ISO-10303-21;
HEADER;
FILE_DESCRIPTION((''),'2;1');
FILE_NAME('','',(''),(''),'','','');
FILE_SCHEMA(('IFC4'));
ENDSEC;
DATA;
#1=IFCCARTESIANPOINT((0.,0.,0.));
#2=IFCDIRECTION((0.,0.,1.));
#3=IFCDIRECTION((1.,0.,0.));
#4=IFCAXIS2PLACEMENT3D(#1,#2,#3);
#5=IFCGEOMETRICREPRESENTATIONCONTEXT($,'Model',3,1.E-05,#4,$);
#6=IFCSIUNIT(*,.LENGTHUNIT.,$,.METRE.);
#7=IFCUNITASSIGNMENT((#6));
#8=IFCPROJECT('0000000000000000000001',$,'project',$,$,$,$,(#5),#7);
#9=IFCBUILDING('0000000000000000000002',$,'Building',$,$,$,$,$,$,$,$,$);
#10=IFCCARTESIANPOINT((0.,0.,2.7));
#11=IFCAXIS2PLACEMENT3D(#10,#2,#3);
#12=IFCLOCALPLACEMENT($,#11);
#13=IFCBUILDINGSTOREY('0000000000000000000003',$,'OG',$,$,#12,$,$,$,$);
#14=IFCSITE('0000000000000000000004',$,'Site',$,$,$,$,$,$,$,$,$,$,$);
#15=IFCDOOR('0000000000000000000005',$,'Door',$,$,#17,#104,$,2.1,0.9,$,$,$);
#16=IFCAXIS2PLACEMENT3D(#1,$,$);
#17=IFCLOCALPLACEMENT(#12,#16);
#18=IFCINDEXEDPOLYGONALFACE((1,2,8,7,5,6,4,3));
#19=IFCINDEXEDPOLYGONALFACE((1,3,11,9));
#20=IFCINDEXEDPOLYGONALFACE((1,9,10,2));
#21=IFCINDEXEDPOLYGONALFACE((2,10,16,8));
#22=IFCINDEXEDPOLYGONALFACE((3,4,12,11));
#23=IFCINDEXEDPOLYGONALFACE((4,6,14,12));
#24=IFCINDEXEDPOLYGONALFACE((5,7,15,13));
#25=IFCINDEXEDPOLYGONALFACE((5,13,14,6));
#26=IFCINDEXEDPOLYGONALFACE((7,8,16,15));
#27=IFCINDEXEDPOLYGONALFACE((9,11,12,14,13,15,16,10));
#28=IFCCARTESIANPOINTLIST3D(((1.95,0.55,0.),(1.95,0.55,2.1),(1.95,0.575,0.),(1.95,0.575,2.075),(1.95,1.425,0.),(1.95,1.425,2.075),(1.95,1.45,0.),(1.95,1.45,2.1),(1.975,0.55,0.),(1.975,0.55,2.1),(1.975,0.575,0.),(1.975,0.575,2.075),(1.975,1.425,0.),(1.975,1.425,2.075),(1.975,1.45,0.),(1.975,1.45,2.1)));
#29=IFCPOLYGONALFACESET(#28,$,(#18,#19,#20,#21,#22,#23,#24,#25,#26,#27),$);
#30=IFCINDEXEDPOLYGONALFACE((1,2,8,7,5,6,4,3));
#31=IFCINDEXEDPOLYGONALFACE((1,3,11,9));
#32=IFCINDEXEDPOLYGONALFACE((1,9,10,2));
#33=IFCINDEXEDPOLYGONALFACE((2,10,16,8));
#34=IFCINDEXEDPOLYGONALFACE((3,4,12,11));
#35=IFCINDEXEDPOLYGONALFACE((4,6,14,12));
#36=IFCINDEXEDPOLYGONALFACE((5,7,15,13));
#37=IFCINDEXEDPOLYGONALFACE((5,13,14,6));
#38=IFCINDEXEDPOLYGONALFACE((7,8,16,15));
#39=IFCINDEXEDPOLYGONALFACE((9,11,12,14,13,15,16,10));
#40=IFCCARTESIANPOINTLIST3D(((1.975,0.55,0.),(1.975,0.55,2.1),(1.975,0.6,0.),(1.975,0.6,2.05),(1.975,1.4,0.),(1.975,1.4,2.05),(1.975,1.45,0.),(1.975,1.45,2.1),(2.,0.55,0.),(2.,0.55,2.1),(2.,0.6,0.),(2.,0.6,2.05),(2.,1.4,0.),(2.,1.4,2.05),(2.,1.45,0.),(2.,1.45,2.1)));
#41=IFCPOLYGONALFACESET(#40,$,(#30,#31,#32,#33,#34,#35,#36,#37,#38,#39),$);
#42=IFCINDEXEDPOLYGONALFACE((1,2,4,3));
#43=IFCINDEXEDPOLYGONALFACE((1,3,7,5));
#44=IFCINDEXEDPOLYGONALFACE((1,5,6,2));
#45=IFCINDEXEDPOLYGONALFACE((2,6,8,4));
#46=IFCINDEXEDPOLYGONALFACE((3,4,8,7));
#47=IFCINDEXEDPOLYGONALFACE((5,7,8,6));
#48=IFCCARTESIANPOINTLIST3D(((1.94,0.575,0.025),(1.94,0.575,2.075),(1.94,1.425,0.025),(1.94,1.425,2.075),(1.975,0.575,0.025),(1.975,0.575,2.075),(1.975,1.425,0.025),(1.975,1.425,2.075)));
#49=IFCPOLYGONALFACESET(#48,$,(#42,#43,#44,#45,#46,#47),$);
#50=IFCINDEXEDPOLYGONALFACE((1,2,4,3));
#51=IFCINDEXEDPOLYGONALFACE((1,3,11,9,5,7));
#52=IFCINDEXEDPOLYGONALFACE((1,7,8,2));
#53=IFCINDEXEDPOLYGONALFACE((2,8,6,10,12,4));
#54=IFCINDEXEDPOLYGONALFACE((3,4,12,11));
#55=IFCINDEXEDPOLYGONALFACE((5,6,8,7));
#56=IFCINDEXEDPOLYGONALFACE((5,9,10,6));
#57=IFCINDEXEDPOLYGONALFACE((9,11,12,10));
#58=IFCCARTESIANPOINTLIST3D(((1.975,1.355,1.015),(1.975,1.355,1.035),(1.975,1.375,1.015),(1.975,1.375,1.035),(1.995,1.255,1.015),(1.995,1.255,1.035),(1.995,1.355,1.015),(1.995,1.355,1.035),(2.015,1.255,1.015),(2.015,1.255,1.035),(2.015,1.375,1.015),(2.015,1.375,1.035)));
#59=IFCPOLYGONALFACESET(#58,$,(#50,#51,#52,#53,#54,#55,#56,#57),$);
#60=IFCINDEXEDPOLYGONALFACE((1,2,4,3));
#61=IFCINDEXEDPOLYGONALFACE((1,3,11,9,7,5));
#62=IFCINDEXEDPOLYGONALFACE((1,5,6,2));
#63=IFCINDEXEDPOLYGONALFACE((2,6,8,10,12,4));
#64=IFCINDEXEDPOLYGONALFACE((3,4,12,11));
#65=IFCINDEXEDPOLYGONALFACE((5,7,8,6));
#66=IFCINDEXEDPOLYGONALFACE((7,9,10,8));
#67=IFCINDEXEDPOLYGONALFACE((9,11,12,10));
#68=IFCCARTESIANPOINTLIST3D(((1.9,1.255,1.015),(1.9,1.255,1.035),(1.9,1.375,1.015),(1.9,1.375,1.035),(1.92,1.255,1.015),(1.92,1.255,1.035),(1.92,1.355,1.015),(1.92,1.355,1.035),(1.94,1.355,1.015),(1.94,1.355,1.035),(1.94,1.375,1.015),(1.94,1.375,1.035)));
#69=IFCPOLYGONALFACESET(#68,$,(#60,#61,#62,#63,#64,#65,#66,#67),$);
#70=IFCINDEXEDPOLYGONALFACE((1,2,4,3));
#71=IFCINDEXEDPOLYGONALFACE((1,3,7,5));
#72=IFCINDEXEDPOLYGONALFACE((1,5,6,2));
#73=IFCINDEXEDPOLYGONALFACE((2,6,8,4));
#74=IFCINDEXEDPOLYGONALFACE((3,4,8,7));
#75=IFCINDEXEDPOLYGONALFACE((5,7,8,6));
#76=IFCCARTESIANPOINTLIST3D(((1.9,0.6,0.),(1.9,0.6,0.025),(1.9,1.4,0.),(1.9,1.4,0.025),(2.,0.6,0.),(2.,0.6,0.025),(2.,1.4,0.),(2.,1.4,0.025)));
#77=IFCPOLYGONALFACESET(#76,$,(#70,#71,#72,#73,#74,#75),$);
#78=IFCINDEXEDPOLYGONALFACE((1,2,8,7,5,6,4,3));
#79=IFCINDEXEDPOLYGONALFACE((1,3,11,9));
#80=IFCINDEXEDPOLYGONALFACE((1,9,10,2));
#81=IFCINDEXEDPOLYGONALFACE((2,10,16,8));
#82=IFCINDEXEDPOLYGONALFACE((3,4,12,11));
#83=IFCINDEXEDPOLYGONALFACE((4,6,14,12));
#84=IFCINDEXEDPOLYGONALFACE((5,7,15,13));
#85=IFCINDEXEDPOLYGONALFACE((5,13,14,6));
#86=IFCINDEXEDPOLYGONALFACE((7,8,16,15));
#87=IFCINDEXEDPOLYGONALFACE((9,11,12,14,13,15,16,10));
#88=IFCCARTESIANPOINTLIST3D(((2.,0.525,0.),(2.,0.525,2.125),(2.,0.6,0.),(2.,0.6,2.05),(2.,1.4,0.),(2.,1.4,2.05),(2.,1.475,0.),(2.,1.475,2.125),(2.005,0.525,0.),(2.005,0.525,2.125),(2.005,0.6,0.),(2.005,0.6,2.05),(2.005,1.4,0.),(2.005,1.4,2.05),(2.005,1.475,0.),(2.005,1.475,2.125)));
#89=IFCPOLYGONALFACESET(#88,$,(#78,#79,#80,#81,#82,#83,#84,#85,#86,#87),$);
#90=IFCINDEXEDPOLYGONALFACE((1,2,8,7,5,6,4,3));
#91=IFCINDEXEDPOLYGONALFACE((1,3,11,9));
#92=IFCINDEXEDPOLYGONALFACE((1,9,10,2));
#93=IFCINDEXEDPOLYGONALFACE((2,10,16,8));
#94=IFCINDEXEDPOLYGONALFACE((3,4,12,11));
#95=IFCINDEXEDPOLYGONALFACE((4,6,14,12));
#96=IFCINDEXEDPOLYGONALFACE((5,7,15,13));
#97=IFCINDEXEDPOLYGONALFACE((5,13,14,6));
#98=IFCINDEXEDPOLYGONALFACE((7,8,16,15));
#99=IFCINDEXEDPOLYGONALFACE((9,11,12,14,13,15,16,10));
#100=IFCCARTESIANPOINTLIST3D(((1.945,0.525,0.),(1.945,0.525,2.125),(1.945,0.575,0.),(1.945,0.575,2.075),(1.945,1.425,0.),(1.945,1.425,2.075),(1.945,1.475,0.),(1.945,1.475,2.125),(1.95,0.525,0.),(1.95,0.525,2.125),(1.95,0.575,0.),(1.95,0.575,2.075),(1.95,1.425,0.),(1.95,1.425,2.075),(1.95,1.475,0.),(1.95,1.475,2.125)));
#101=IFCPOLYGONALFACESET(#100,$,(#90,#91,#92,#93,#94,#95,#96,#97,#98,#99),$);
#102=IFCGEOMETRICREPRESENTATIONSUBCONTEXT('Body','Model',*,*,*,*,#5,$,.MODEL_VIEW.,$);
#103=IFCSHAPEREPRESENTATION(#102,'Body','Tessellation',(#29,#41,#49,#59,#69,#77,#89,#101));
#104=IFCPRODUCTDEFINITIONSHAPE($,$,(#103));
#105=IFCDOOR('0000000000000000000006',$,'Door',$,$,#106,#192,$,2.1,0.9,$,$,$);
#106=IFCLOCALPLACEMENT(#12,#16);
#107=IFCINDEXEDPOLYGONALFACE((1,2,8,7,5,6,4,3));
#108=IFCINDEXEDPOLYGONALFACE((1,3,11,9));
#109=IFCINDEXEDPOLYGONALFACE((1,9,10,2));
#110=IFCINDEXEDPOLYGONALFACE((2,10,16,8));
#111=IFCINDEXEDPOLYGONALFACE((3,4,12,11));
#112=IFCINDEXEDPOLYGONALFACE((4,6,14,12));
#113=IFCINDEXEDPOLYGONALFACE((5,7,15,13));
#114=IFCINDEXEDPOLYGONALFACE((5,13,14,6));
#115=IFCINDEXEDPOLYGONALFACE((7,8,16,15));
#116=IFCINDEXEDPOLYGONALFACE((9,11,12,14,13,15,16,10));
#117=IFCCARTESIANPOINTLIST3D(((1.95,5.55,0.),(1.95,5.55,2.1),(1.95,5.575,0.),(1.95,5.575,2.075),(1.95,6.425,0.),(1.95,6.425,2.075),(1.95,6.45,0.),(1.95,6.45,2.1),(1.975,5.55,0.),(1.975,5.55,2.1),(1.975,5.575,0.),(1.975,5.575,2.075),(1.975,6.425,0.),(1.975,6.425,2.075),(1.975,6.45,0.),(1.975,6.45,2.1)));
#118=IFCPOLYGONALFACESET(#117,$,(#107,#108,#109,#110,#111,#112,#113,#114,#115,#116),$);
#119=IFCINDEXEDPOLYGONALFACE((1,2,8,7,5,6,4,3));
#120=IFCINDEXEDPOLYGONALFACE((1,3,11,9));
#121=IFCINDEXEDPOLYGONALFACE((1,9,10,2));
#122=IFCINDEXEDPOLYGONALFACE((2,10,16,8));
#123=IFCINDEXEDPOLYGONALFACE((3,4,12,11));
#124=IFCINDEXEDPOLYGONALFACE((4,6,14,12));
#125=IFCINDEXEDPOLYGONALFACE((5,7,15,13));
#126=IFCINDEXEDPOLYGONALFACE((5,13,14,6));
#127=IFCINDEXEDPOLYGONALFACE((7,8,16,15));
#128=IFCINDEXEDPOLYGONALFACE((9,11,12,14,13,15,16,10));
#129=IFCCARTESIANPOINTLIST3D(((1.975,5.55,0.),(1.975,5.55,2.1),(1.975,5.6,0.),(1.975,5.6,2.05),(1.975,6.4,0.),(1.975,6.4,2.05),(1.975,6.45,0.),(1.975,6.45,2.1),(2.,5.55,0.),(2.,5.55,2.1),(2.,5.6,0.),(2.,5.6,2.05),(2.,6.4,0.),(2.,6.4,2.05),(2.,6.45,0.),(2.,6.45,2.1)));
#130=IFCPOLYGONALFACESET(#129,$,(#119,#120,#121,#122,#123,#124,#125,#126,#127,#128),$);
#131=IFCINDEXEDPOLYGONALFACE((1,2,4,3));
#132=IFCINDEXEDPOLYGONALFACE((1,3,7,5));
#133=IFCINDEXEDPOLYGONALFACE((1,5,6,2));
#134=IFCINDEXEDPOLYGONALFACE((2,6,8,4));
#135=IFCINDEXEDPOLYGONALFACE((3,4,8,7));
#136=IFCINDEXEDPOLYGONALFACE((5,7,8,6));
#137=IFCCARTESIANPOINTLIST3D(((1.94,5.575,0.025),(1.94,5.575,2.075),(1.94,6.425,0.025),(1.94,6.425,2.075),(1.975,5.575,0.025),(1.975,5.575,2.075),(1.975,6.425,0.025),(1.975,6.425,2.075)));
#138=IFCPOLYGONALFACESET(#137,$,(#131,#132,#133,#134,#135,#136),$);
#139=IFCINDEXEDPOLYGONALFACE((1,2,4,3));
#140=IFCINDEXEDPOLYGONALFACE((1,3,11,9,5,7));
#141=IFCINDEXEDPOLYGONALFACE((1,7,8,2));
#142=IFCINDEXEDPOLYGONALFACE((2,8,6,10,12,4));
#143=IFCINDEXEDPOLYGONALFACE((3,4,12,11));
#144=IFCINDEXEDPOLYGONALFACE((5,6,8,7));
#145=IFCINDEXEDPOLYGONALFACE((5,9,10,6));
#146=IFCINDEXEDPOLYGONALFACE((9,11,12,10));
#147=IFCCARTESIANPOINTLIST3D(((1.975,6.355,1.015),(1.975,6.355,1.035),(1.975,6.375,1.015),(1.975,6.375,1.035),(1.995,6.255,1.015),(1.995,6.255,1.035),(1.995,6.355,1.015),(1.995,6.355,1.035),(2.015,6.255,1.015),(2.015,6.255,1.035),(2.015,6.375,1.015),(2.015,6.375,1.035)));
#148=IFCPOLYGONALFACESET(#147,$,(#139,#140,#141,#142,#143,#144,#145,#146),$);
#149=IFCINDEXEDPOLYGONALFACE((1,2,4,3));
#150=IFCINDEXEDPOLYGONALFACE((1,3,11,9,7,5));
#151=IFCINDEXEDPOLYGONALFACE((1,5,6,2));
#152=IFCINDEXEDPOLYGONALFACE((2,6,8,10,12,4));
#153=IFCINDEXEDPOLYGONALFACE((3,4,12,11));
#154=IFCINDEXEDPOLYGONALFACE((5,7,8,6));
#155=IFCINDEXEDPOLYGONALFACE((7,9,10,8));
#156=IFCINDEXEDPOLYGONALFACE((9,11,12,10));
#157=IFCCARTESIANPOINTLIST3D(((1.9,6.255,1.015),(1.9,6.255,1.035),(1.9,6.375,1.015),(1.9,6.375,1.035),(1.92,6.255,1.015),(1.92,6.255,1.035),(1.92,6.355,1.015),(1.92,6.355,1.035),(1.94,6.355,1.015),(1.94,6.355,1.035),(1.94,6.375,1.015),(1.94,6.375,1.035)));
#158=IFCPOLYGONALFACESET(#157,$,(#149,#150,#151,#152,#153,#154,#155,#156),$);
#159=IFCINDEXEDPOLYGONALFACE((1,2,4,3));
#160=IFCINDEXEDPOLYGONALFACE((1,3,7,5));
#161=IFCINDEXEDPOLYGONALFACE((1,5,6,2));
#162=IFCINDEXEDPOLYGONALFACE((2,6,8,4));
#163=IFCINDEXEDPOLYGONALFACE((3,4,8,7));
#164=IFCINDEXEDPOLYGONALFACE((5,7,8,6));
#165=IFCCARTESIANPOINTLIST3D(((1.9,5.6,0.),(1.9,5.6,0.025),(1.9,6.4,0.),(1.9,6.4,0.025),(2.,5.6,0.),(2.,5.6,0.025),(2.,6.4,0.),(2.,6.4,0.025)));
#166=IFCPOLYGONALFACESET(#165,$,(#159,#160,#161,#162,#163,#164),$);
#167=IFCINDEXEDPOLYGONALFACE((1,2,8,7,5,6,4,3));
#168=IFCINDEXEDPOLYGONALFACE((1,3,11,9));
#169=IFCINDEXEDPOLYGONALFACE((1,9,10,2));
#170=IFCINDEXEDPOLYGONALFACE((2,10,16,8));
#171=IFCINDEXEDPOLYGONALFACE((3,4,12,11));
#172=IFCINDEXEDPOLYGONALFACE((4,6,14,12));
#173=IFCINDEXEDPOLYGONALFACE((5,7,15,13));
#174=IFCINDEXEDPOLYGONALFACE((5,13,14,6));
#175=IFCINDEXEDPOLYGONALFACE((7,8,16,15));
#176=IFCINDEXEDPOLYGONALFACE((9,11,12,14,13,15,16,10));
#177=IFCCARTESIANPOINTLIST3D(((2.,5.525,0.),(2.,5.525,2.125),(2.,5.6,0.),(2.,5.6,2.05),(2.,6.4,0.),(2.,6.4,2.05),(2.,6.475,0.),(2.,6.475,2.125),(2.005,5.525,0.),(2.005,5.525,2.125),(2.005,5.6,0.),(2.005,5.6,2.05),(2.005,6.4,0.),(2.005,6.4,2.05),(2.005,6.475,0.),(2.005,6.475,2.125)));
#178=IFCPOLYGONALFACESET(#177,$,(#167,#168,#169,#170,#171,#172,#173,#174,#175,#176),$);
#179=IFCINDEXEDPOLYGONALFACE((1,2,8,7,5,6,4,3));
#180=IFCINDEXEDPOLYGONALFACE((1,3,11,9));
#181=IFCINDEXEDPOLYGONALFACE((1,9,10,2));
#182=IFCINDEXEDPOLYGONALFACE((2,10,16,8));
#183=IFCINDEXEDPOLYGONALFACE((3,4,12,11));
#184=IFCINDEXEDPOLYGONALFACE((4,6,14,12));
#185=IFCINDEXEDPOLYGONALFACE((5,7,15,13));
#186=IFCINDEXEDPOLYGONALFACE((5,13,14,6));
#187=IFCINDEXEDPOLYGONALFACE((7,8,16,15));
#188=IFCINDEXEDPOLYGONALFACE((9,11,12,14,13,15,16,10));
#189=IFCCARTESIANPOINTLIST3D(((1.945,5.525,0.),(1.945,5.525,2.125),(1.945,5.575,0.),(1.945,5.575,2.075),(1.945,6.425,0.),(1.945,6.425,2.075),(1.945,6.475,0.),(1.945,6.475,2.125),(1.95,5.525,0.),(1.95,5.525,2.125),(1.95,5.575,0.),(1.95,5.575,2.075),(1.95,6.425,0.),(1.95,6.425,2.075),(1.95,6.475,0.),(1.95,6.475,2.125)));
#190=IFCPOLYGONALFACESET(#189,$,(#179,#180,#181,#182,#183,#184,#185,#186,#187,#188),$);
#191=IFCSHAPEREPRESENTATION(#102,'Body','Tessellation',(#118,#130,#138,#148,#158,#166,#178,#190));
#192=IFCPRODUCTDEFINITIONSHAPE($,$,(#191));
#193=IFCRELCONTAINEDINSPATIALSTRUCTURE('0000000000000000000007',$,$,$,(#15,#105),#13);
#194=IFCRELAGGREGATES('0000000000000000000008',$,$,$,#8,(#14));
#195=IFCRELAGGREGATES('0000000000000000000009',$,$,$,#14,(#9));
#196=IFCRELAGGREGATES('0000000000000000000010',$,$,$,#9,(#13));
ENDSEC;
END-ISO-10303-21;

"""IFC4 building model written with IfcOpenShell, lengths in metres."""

from ifc_helpers import new_model, si_unit, frame, origin_with_axes, place, context, subcontext, project, spatial, line, indexed_curve, outline, extrude, element, save


model = new_model("IFC4")

# Units and contexts
model_context = context("Model", 3, precision=1e-05, world=origin_with_axes())
body_context = subcontext(model_context, "Body", "Model", "MODEL_VIEW")
ifc_project = project(units=[si_unit("LENGTHUNIT", "METRE")], contexts=[model_context])

# Site, building, storey
site = spatial("IfcSite", under=ifc_project, Name="Site")
building = spatial("IfcBuilding", under=site, Name="Building")
storey_placement = place(None, frame((0.0, 0.0, 2.7), z_axis=(0.0, 0.0, 1.0), x_axis=(1.0, 0.0, 0.0)))
storey = spatial("IfcBuildingStorey", under=building, at=storey_placement, Name="OG")

# Doors
door_1_placement = place(storey_placement, frame((2.0, 0.55, 0.0), z_axis=(0.0, 0.0, 1.0), x_axis=(0.0, 1.0, 0.0)))
element("IfcDoor", 1, at=door_1_placement, inside=storey, Name="Door", OverallHeight=2.1, OverallWidth=0.9, context=body_context, shape_type="SweptSolid", body=[
    extrude(outline(indexed_curve([(0.0, 0.0), (0.0, 2.1), (0.9, 2.1), (0.9, 0.0), (0.875, 0.0), (0.875, 2.075), (0.025, 2.075), (0.025, 0.0)], segments=[line(1, 2, 3, 4, 5, 6, 7, 8, 1)])), frame((0.0, 0.025, 0.0), z_axis=(0.0, -1.0, 0.0), x_axis=(1.0, 0.0, 0.0)), (0.0, 0.0, -1.0), 0.025),
    extrude(outline(indexed_curve([(0.0, 0.0), (0.0, 2.1), (0.9, 2.1), (0.9, 0.0), (0.85, 0.0), (0.85, 2.05), (0.05, 2.05), (0.05, 0.0)], segments=[line(1, 2, 3, 4, 5, 6, 7, 8, 1)])), frame((0.0, 0.0, 0.0), z_axis=(0.0, -1.0, 0.0), x_axis=(1.0, 0.0, 0.0)), (0.0, 0.0, -1.0), 0.025),
    extrude(outline(indexed_curve([(0.0, 0.0), (0.85, 0.0), (0.85, 0.035), (0.0, 0.035)], segments=[line(1, 2, 3, 4, 1)])), frame((0.025, 0.025, 0.025), z_axis=(0.0, 0.0, 1.0), x_axis=(1.0, 0.0, 0.0)), (0.0, 0.0, 1.0), 2.05),
    extrude(outline(indexed_curve([(0.0, 0.0), (0.0, -0.04), (-0.12, -0.04), (-0.12, -0.02), (-0.02, -0.02), (-0.02, 0.0)], segments=[line(1, 2, 3, 4, 5, 6, 1)])), frame((0.825, 0.025, 1.015), z_axis=(0.0, 0.0, 1.0), x_axis=(1.0, 0.0, 0.0)), (0.0, 0.0, 1.0), 0.02),
    extrude(outline(indexed_curve([(0.0, 0.0), (0.0, 0.04), (-0.12, 0.04), (-0.12, 0.02), (-0.02, 0.02), (-0.02, 0.0)], segments=[line(1, 2, 3, 4, 5, 6, 1)])), frame((0.825, 0.06, 1.015), z_axis=(0.0, 0.0, 1.0), x_axis=(1.0, 0.0, 0.0)), (0.0, 0.0, 1.0), 0.02),
    extrude(outline(indexed_curve([(0.0, 0.0), (0.8, 0.0), (0.8, 0.1), (0.0, 0.1)], segments=[line(1, 2, 3, 4, 1)])), frame((0.05, 0.0, 0.0), z_axis=(0.0, 0.0, 1.0), x_axis=(1.0, 0.0, 0.0)), (0.0, 0.0, 1.0), 0.025),
    extrude(outline(indexed_curve([(0.0, 0.0), (0.0, 2.125), (0.95, 2.125), (0.95, 0.0), (0.875, 0.0), (0.875, 2.05), (0.075, 2.05), (0.075, 0.0)], segments=[line(1, 2, 3, 4, 5, 6, 7, 8, 1)])), frame((-0.025, -0.005, 0.0), z_axis=(0.0, -1.0, 0.0), x_axis=(1.0, 0.0, 0.0)), (0.0, 0.0, -1.0), 0.005),
    extrude(outline(indexed_curve([(0.0, 0.0), (0.0, 2.125), (0.95, 2.125), (0.95, 0.0), (0.9, 0.0), (0.9, 2.075), (0.05, 2.075), (0.05, 0.0)], segments=[line(1, 2, 3, 4, 5, 6, 7, 8, 1)])), frame((-0.025, 0.05, 0.0), z_axis=(0.0, -1.0, 0.0), x_axis=(1.0, 0.0, 0.0)), (0.0, 0.0, -1.0), 0.005),
])
door_2_placement = place(storey_placement, frame((2.0, 5.55, 0.0), z_axis=(0.0, 0.0, 1.0), x_axis=(0.0, 1.0, 0.0)))
element("IfcDoor", 2, at=door_2_placement, inside=storey, Name="Door", OverallHeight=2.1, OverallWidth=0.9, context=body_context, shape_type="SweptSolid", body=[
    extrude(outline(indexed_curve([(0.0, 0.0), (0.0, 2.1), (0.9, 2.1), (0.9, 0.0), (0.875, 0.0), (0.875, 2.075), (0.025, 2.075), (0.025, 0.0)], segments=[line(1, 2, 3, 4, 5, 6, 7, 8, 1)])), frame((0.0, 0.025, 0.0), z_axis=(0.0, -1.0, 0.0), x_axis=(1.0, 0.0, 0.0)), (0.0, 0.0, -1.0), 0.025),
    extrude(outline(indexed_curve([(0.0, 0.0), (0.0, 2.1), (0.9, 2.1), (0.9, 0.0), (0.85, 0.0), (0.85, 2.05), (0.05, 2.05), (0.05, 0.0)], segments=[line(1, 2, 3, 4, 5, 6, 7, 8, 1)])), frame((0.0, 0.0, 0.0), z_axis=(0.0, -1.0, 0.0), x_axis=(1.0, 0.0, 0.0)), (0.0, 0.0, -1.0), 0.025),
    extrude(outline(indexed_curve([(0.0, 0.0), (0.85, 0.0), (0.85, 0.035), (0.0, 0.035)], segments=[line(1, 2, 3, 4, 1)])), frame((0.025, 0.025, 0.025), z_axis=(0.0, 0.0, 1.0), x_axis=(1.0, 0.0, 0.0)), (0.0, 0.0, 1.0), 2.05),
    extrude(outline(indexed_curve([(0.0, 0.0), (0.0, -0.04), (-0.12, -0.04), (-0.12, -0.02), (-0.02, -0.02), (-0.02, 0.0)], segments=[line(1, 2, 3, 4, 5, 6, 1)])), frame((0.825, 0.025, 1.015), z_axis=(0.0, 0.0, 1.0), x_axis=(1.0, 0.0, 0.0)), (0.0, 0.0, 1.0), 0.02),
    extrude(outline(indexed_curve([(0.0, 0.0), (0.0, 0.04), (-0.12, 0.04), (-0.12, 0.02), (-0.02, 0.02), (-0.02, 0.0)], segments=[line(1, 2, 3, 4, 5, 6, 1)])), frame((0.825, 0.06, 1.015), z_axis=(0.0, 0.0, 1.0), x_axis=(1.0, 0.0, 0.0)), (0.0, 0.0, 1.0), 0.02),
    extrude(outline(indexed_curve([(0.0, 0.0), (0.8, 0.0), (0.8, 0.1), (0.0, 0.1)], segments=[line(1, 2, 3, 4, 1)])), frame((0.05, 0.0, 0.0), z_axis=(0.0, 0.0, 1.0), x_axis=(1.0, 0.0, 0.0)), (0.0, 0.0, 1.0), 0.025),
    extrude(outline(indexed_curve([(0.0, 0.0), (0.0, 2.125), (0.95, 2.125), (0.95, 0.0), (0.875, 0.0), (0.875, 2.05), (0.075, 2.05), (0.075, 0.0)], segments=[line(1, 2, 3, 4, 5, 6, 7, 8, 1)])), frame((-0.025, -0.005, 0.0), z_axis=(0.0, -1.0, 0.0), x_axis=(1.0, 0.0, 0.0)), (0.0, 0.0, -1.0), 0.005),
    extrude(outline(indexed_curve([(0.0, 0.0), (0.0, 2.125), (0.95, 2.125), (0.95, 0.0), (0.9, 0.0), (0.9, 2.075), (0.05, 2.075), (0.05, 0.0)], segments=[line(1, 2, 3, 4, 5, 6, 7, 8, 1)])), frame((-0.025, 0.05, 0.0), z_axis=(0.0, -1.0, 0.0), x_axis=(1.0, 0.0, 0.0)), (0.0, 0.0, -1.0), 0.005),
])

save(model, "model.ifc")
